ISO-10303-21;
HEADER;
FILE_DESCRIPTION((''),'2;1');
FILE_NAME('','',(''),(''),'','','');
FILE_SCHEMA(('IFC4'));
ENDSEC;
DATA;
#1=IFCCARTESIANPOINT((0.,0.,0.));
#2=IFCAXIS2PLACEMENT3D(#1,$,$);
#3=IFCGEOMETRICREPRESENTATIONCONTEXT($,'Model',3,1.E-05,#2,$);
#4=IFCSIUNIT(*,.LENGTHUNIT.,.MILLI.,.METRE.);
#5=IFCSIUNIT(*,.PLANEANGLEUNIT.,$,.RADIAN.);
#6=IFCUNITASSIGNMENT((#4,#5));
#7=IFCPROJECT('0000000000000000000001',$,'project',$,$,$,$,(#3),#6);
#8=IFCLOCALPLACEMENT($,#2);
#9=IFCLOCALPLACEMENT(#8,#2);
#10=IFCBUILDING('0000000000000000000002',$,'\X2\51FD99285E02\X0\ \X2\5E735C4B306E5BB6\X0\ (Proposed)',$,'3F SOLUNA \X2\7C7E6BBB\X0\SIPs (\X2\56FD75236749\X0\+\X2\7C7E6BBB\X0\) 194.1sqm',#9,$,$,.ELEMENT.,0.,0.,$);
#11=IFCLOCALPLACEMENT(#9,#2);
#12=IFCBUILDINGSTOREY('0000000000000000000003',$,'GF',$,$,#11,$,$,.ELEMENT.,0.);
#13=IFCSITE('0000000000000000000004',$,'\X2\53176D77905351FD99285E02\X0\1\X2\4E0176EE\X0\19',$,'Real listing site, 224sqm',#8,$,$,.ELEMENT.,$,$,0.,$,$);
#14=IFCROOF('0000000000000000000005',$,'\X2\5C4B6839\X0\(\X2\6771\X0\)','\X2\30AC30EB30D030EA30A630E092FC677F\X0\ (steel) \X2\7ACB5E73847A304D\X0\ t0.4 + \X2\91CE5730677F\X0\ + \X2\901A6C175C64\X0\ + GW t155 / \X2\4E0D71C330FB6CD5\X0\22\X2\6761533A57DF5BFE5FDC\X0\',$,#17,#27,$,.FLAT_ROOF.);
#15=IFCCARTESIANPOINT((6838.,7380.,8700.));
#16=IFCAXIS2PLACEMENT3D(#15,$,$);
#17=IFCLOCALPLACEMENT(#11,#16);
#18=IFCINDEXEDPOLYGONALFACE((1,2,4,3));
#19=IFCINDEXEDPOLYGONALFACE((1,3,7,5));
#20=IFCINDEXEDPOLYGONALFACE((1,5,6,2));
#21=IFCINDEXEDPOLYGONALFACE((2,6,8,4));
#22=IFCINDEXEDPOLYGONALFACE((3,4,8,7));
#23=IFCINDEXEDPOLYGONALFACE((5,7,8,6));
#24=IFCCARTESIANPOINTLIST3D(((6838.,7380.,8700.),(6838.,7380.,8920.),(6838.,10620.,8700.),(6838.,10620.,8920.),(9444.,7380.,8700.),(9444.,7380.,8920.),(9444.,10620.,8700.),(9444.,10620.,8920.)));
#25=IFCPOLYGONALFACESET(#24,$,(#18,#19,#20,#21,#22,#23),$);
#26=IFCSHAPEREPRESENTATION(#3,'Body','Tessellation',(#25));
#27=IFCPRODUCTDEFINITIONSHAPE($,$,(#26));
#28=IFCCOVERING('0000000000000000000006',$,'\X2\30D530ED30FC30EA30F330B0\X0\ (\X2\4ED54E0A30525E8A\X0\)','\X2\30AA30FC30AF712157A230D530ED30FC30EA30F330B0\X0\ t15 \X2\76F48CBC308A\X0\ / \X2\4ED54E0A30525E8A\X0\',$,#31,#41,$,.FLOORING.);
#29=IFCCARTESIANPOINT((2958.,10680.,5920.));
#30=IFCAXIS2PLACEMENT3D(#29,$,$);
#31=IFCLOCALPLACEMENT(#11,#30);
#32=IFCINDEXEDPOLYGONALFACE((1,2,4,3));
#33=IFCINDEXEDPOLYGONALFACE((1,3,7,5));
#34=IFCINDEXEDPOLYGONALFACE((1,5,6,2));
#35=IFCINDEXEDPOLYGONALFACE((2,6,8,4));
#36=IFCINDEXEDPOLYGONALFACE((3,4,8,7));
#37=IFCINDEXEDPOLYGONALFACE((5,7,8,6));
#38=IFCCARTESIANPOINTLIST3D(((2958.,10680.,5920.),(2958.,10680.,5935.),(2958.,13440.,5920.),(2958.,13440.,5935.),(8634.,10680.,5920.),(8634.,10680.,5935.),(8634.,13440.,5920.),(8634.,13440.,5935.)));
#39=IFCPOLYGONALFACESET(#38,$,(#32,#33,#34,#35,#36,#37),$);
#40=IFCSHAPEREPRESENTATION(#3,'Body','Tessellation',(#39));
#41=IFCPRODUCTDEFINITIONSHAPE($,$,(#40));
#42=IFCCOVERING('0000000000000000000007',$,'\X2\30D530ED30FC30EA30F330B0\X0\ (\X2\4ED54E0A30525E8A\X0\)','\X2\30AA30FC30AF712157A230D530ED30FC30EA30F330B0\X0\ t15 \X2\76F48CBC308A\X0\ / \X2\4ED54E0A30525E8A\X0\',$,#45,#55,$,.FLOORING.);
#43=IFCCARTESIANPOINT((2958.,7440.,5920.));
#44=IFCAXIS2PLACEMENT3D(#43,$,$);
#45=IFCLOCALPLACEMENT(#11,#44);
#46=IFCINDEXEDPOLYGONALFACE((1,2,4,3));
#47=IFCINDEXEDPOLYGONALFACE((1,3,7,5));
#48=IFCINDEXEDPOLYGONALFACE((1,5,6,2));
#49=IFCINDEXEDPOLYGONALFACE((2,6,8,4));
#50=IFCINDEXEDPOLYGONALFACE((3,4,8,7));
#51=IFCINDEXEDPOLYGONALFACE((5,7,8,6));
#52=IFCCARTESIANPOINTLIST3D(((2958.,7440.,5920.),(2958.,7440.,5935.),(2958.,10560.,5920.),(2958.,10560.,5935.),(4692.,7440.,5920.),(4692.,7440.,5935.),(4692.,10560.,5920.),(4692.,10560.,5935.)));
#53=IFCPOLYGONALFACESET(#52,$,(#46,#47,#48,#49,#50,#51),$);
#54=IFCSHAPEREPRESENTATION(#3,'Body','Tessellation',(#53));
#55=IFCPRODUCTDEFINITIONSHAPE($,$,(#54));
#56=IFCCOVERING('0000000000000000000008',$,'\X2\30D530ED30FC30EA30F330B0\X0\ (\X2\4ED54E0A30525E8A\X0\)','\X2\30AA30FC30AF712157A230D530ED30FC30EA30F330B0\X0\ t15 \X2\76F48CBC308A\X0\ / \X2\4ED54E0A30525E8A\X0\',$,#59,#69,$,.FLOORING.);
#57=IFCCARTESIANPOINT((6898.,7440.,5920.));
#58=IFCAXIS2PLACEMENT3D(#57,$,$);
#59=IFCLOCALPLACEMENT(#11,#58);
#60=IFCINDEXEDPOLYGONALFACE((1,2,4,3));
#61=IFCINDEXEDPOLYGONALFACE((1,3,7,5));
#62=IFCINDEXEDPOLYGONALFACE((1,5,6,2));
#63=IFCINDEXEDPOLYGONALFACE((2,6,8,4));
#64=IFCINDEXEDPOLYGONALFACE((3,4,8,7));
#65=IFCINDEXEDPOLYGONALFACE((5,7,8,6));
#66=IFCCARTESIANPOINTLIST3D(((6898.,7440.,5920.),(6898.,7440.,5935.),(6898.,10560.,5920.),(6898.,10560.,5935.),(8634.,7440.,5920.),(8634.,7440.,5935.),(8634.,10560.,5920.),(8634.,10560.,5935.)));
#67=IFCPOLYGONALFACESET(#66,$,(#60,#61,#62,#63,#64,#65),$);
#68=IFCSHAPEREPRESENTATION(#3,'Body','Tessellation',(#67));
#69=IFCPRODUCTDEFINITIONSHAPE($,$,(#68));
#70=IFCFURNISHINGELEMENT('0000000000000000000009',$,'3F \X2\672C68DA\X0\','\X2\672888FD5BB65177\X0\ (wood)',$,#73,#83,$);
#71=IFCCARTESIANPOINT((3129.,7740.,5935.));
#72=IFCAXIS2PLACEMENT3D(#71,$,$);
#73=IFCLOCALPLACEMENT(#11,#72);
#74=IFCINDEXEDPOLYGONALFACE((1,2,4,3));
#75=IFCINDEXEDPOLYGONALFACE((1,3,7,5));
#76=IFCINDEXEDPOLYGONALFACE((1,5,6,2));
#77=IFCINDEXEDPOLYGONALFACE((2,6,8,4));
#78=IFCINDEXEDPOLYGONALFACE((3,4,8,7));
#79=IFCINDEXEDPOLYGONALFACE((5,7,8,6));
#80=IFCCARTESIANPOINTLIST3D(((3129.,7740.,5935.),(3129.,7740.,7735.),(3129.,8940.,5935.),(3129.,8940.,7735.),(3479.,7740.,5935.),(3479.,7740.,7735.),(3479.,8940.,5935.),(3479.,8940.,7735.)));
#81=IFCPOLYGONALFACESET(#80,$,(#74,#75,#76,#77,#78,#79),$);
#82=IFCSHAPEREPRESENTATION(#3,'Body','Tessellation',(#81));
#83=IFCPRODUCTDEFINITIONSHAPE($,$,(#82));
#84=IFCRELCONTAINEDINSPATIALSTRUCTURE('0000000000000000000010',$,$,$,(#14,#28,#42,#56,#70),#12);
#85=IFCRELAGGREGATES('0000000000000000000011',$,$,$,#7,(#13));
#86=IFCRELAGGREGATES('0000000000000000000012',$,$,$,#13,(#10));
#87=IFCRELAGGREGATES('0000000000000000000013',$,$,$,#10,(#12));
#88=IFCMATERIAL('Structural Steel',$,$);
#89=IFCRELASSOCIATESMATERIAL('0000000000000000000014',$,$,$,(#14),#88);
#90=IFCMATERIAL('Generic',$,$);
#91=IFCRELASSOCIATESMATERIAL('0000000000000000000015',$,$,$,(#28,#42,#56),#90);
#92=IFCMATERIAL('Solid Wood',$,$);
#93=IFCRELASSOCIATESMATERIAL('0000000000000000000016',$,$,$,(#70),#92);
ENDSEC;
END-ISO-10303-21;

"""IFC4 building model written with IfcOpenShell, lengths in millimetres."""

from ifc_helpers import new_model, si_unit, frame, frame_2d, origin, place, context, project, spatial, rectangle, extrude, material, element, save


model = new_model("IFC4")

# Units and contexts
model_context = context("Model", 3, precision=1e-05, world=origin())
ifc_project = project(units=[si_unit("LENGTHUNIT", "METRE", prefix="MILLI"), si_unit("PLANEANGLEUNIT", "RADIAN")], contexts=[model_context])

# Site, building, storey
site_placement = place(None, origin())
site = spatial("IfcSite", under=ifc_project, at=site_placement, Name="北海道函館市1丁目19", ObjectType="Real listing site, 224sqm", CompositionType="ELEMENT", RefElevation=0.0)
building_placement = place(site_placement, origin())
building = spatial("IfcBuilding", under=site, at=building_placement, Name="函館市 平屋の家 (Proposed)", ObjectType="3F SOLUNA 籾殻SIPs (国産杉+籾殻) 194.1sqm", CompositionType="ELEMENT", ElevationOfRefHeight=0.0, ElevationOfTerrain=0.0)
storey_placement = place(building_placement, origin())
storey = spatial("IfcBuildingStorey", under=building, at=storey_placement, Name="GF", CompositionType="ELEMENT", Elevation=0.0)

# Shared definitions
ifc_material_1 = material(Name="Solid Wood")

# Shared definitions
ifc_material_2 = material(Name="Generic")

# Roof
ifc_material_3 = material(Name="Structural Steel")
roof_1_placement = place(storey_placement, frame((6838.0, 7380.0, 8700.0)))
element("IfcRoof", 1, at=roof_1_placement, inside=storey, material=ifc_material_3, Name="屋根(東)", Description="ガルバリウム鋼板 (steel) 立平葺き t0.4 + 野地板 + 通気層 + GW t155 / 不燃・法22条区域対応", PredefinedType="FLAT_ROOF", context=model_context, shape_type="SweptSolid", body=[
    extrude(rectangle(XDim=2606.0, YDim=3240.0, at=frame_2d((1303.0, 1620.0))), frame((6838.0, 7380.0, 8700.0)), (0.0, 0.0, 1.0), 220.0),
])

# Coverings
covering_1_placement = place(storey_placement, frame((2958.0, 10680.0, 5920.0)))
element("IfcCovering", 2, at=covering_1_placement, inside=storey, material=ifc_material_2, Name="フローリング (仕上げ床)", Description="オーク無垢フローリング t15 直貼り / 仕上げ床", PredefinedType="FLOORING", context=model_context, shape_type="SweptSolid", body=[
    extrude(rectangle(XDim=5676.0, YDim=2760.0, at=frame_2d((2838.0, 1380.0))), frame((2958.0, 10680.0, 5920.0)), (0.0, 0.0, 1.0), 15.0),
])
covering_2_placement = place(storey_placement, frame((2958.0, 7440.0, 5920.0)))
element("IfcCovering", 3, at=covering_2_placement, inside=storey, material=ifc_material_2, Name="フローリング (仕上げ床)", Description="オーク無垢フローリング t15 直貼り / 仕上げ床", PredefinedType="FLOORING", context=model_context, shape_type="SweptSolid", body=[
    extrude(rectangle(XDim=1734.0, YDim=3120.0, at=frame_2d((867.0, 1560.0))), frame((2958.0, 7440.0, 5920.0)), (0.0, 0.0, 1.0), 15.0),
])
covering_3_placement = place(storey_placement, frame((6898.0, 7440.0, 5920.0)))
element("IfcCovering", 4, at=covering_3_placement, inside=storey, material=ifc_material_2, Name="フローリング (仕上げ床)", Description="オーク無垢フローリング t15 直貼り / 仕上げ床", PredefinedType="FLOORING", context=model_context, shape_type="SweptSolid", body=[
    extrude(rectangle(XDim=1736.0, YDim=3120.0, at=frame_2d((868.0, 1560.0))), frame((6898.0, 7440.0, 5920.0)), (0.0, 0.0, 1.0), 15.0),
])

# Furnishing element
furnishing_placement = place(storey_placement, frame((3129.0, 7740.0, 5935.0)))
element("IfcFurnishingElement", 5, at=furnishing_placement, inside=storey, material=ifc_material_1, Name="3F 本棚", Description="木製家具 (wood)", context=model_context, shape_type="SweptSolid", body=[
    extrude(rectangle(XDim=350.0, YDim=1200.0, at=frame_2d((175.0, 600.0))), frame((3129.0, 7740.0, 5935.0)), (0.0, 0.0, 1.0), 1800.0),
])

save(model, "model.ifc")
